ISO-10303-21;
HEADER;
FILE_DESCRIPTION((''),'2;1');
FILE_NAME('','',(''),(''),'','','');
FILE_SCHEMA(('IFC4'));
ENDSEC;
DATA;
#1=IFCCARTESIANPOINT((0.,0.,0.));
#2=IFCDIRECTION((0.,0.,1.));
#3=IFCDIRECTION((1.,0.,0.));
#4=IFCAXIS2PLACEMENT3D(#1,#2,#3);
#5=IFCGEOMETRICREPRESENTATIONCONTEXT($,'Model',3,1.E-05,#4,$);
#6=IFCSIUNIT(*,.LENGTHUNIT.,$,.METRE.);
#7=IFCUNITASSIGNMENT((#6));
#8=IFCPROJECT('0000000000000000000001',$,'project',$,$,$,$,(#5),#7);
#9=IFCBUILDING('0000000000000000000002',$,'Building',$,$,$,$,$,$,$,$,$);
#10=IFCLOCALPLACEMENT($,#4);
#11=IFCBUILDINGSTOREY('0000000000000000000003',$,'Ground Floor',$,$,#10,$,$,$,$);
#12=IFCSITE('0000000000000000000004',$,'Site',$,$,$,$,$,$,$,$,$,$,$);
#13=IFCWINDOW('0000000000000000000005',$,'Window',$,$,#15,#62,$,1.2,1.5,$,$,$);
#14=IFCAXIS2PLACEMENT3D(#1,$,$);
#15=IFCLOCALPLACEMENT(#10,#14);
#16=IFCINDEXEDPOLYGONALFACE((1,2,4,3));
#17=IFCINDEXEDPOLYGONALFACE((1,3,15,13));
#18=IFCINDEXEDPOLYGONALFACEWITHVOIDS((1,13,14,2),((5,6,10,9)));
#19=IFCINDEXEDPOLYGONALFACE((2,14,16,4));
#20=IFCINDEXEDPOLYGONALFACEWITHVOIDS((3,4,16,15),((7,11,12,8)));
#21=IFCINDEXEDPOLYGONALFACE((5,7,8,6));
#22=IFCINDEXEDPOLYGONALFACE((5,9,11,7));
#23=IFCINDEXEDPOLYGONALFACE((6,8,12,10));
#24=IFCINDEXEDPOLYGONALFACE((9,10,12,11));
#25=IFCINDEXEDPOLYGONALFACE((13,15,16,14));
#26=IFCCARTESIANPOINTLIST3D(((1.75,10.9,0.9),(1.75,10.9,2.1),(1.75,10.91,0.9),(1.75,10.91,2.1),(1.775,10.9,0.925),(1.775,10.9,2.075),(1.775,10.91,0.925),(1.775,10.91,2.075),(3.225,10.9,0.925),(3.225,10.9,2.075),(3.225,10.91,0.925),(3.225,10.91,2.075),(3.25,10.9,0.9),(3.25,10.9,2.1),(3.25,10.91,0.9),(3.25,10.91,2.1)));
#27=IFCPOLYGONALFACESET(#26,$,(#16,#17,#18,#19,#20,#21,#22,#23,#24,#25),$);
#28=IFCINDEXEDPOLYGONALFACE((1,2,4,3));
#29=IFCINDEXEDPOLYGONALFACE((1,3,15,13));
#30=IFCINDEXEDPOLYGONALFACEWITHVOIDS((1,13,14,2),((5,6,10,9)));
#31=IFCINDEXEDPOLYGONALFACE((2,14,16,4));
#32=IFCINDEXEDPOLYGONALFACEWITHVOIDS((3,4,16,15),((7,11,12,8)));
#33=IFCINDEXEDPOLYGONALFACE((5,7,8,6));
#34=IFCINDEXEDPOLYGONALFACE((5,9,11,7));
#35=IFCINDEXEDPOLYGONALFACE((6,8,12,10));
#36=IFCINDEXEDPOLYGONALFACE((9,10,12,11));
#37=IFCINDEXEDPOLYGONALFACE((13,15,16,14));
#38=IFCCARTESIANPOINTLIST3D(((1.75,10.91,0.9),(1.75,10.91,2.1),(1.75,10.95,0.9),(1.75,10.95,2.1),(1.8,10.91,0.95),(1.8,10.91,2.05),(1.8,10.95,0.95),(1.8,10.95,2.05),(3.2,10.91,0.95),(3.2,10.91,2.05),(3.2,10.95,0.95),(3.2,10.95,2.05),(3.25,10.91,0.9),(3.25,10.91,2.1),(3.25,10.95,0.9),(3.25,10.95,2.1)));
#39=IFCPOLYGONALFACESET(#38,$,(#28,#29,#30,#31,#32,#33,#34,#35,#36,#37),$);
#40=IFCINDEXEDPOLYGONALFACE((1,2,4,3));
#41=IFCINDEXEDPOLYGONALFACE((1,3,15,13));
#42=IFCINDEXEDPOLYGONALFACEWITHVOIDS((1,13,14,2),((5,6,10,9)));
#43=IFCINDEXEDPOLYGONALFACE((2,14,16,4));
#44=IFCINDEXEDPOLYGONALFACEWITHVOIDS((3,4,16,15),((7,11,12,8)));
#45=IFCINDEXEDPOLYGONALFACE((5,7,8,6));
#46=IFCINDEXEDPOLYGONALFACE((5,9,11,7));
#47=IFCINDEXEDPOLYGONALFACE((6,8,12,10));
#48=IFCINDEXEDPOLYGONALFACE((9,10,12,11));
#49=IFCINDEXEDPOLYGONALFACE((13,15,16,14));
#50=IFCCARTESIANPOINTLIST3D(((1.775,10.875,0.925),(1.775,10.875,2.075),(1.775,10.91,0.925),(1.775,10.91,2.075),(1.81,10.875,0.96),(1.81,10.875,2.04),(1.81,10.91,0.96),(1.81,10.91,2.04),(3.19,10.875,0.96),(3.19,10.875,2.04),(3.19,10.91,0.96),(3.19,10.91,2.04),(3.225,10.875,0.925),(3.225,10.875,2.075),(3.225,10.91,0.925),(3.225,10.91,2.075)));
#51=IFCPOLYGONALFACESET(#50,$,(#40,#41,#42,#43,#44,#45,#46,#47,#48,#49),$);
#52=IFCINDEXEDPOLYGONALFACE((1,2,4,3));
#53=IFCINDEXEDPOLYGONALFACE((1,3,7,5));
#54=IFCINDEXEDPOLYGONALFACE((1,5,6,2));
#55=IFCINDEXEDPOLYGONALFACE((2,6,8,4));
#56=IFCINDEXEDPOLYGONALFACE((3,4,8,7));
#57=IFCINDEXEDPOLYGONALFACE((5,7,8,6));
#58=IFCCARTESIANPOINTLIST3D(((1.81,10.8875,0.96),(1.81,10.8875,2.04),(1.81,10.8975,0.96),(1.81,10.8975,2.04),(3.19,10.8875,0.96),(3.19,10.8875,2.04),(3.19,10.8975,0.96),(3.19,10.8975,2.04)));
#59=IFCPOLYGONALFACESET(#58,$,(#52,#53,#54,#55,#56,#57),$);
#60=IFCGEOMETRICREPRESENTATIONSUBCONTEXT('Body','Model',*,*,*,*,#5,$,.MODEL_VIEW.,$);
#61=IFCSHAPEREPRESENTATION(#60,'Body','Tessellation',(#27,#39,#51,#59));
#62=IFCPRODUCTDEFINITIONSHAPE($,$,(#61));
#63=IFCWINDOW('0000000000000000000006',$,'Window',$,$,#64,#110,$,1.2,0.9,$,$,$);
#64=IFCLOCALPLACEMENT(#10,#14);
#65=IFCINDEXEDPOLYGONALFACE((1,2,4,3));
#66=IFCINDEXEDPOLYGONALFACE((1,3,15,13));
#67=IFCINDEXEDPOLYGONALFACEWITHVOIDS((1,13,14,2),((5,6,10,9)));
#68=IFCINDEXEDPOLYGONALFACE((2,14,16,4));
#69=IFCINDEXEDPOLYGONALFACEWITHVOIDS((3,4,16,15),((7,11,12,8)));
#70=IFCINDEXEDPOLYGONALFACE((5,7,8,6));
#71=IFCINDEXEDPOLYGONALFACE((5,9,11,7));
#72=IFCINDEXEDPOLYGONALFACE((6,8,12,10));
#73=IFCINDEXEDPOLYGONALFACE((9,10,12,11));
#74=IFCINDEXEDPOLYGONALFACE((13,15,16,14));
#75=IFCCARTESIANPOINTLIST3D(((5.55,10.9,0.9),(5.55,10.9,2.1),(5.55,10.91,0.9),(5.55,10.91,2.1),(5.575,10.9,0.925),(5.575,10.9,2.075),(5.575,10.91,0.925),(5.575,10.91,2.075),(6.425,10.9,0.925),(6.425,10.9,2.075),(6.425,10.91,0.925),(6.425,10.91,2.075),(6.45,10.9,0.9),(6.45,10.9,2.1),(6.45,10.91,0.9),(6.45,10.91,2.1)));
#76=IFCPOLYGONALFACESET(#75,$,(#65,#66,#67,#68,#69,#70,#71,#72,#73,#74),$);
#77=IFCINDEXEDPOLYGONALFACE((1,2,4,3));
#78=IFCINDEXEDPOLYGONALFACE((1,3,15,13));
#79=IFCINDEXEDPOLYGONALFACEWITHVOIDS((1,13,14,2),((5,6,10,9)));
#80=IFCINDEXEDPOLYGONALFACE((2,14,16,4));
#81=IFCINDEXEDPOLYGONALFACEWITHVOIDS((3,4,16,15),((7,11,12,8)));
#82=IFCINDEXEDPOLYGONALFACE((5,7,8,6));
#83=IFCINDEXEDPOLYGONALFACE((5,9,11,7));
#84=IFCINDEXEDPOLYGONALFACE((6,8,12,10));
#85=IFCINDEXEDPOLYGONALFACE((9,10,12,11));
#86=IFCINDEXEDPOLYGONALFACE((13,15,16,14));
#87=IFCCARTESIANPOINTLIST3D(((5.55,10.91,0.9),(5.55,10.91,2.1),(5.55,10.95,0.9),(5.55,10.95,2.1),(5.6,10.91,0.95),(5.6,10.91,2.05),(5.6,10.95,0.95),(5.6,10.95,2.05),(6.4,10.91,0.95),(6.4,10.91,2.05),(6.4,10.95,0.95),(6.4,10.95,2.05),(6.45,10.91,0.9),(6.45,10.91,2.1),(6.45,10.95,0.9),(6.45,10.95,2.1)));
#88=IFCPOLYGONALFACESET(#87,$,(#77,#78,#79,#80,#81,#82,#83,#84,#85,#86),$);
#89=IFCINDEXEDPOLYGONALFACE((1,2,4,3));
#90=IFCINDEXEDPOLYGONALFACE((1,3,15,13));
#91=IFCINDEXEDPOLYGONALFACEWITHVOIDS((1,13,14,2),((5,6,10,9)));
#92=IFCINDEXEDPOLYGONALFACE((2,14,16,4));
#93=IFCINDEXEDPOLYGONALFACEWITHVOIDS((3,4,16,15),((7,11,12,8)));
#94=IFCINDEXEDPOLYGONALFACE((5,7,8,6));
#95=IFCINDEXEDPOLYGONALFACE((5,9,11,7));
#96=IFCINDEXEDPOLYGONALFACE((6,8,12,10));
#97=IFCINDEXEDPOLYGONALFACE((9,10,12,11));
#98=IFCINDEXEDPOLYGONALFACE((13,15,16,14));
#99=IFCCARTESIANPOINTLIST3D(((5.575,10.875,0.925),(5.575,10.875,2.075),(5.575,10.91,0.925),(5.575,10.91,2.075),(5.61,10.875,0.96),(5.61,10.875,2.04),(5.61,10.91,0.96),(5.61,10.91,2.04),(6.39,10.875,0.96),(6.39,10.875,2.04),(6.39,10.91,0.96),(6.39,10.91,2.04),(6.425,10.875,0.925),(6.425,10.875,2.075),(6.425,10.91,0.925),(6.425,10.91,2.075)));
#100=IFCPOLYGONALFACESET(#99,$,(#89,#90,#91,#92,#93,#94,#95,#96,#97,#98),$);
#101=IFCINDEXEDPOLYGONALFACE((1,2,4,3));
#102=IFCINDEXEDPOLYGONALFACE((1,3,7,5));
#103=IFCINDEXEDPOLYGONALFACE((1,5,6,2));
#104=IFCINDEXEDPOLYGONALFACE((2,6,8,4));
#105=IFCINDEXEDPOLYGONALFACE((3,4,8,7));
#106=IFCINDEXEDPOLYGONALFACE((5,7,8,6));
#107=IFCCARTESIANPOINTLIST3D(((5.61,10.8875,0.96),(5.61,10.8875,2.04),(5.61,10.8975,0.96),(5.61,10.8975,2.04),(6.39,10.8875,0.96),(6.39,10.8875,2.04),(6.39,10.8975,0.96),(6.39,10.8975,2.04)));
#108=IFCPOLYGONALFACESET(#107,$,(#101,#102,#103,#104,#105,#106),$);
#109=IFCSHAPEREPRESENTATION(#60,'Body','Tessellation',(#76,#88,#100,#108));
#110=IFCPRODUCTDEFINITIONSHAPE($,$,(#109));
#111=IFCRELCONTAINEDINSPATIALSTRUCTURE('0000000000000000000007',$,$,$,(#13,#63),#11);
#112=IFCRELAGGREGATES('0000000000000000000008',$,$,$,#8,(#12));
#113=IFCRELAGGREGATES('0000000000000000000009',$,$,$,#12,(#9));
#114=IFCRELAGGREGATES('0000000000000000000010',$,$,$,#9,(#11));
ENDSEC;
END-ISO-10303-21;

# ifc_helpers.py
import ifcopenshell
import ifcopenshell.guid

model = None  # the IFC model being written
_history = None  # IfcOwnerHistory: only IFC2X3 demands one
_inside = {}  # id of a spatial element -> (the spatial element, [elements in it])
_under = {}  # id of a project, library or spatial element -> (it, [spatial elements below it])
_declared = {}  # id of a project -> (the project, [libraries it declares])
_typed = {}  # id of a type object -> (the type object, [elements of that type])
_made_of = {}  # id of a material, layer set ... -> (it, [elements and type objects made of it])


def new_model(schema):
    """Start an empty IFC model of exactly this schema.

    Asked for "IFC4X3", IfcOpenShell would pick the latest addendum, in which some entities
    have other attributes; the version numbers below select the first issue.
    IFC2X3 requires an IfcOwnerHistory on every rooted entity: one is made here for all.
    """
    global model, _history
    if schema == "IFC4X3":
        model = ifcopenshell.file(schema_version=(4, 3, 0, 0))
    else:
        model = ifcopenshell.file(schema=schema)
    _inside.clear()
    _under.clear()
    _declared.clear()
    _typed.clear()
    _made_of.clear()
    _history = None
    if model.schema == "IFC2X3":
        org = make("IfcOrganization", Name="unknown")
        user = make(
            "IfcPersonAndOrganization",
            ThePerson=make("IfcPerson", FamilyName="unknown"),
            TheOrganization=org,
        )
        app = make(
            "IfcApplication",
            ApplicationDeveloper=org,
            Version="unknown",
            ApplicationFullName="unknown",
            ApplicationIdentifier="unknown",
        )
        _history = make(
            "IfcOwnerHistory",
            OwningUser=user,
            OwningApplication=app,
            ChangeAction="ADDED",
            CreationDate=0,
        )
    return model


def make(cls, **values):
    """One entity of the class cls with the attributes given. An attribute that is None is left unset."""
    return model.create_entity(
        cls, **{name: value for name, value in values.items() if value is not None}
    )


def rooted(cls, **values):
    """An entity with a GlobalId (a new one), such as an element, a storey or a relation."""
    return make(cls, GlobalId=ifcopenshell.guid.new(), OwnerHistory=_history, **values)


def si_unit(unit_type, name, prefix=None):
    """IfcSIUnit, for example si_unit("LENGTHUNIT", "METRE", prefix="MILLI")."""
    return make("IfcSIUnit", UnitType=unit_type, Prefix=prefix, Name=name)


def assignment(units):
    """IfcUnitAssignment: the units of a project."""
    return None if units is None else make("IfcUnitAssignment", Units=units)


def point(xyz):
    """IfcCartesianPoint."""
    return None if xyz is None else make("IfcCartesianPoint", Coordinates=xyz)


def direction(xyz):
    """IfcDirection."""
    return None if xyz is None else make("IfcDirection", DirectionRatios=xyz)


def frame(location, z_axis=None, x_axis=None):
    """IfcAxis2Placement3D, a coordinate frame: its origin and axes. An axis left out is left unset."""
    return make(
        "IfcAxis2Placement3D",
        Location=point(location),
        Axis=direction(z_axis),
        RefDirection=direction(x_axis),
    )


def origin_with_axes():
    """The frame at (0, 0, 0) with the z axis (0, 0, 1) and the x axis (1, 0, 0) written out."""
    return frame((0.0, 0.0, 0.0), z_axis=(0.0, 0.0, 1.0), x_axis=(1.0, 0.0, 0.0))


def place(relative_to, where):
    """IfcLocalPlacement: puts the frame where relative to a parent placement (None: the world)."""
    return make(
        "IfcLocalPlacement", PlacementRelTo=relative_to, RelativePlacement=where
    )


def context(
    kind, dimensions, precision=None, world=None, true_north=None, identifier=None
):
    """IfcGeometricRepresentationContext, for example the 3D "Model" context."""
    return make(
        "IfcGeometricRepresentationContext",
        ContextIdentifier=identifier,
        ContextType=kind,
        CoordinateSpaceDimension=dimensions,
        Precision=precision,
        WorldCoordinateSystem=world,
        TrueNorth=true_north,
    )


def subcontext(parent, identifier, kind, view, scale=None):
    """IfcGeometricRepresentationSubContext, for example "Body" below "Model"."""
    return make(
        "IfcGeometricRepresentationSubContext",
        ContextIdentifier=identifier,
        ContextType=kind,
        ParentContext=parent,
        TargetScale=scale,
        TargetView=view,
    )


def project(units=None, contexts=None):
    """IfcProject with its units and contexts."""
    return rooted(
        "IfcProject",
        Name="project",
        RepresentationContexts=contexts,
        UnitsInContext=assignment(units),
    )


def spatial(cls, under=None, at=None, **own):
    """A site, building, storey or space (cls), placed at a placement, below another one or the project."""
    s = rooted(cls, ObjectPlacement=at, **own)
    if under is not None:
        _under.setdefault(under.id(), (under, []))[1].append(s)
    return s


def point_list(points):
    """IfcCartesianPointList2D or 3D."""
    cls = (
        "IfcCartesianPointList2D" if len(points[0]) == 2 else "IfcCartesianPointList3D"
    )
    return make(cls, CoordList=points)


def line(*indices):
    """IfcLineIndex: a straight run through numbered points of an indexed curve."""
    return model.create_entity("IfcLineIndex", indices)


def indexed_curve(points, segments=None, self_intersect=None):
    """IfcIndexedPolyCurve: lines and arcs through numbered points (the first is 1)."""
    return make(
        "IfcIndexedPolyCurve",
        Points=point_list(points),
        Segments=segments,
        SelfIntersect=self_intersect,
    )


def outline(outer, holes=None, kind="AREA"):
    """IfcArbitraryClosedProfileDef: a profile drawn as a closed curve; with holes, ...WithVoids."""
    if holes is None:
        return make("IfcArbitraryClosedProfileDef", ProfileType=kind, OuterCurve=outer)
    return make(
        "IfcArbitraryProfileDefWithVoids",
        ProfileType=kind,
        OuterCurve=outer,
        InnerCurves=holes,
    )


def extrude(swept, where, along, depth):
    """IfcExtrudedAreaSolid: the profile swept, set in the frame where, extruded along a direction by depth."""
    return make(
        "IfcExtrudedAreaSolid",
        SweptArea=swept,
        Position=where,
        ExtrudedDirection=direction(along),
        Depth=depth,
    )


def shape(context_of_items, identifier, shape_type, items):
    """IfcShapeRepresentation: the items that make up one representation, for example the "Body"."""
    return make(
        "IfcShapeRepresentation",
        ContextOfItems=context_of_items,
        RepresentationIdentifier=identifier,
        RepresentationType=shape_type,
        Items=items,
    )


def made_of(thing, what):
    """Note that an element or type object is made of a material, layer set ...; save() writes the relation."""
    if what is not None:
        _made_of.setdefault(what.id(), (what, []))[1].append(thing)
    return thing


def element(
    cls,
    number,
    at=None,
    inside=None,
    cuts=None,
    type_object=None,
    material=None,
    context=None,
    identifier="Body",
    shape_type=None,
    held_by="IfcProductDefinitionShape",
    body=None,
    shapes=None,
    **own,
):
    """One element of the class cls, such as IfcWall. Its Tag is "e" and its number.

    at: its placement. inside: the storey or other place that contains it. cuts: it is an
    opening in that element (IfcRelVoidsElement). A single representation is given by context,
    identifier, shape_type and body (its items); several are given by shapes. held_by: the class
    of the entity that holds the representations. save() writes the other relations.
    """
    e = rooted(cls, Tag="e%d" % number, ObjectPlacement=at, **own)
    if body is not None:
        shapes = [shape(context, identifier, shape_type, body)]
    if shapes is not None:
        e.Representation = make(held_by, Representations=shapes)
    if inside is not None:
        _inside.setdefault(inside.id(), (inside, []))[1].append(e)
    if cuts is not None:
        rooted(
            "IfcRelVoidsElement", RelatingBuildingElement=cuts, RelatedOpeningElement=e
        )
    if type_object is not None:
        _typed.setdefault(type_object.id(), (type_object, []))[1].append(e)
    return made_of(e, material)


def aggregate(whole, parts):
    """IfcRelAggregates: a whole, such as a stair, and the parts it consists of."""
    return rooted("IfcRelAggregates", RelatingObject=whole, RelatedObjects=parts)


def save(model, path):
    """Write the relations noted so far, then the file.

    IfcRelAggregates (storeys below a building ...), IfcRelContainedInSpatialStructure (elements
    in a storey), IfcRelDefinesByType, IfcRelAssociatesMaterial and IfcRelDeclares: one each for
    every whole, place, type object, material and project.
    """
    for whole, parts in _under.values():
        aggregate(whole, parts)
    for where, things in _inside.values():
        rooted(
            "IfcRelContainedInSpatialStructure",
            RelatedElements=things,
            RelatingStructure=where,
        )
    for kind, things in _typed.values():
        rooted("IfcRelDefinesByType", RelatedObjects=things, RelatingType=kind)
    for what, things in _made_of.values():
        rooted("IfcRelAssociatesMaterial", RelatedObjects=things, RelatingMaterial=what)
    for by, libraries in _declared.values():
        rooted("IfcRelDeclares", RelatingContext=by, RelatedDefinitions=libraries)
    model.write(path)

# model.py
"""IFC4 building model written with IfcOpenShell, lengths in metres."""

from ifc_helpers import new_model, si_unit, frame, origin_with_axes, place, context, subcontext, project, spatial, line, indexed_curve, outline, extrude, element, save


model = new_model("IFC4")

# Units and contexts
model_context = context("Model", 3, precision=1e-05, world=origin_with_axes())
body_context = subcontext(model_context, "Body", "Model", "MODEL_VIEW")
ifc_project = project(units=[si_unit("LENGTHUNIT", "METRE")], contexts=[model_context])

# Site, building, storey
site = spatial("IfcSite", under=ifc_project, Name="Site")
building = spatial("IfcBuilding", under=site, Name="Building")
storey_placement = place(None, origin_with_axes())
storey = spatial("IfcBuildingStorey", under=building, at=storey_placement, Name="Ground Floor")

# Windows
window_1_placement = place(storey_placement, frame((3.25, 11.0, 0.9), z_axis=(0.0, 0.0, 1.0), x_axis=(-1.0, 0.0, 0.0)))
element("IfcWindow", 1, at=window_1_placement, inside=storey, Name="Window", OverallHeight=1.2, OverallWidth=1.5, context=body_context, shape_type="SweptSolid", body=[
    extrude(outline(indexed_curve([(0.0, 0.0), (1.5, 0.0), (1.5, 1.2), (0.0, 1.2)], segments=[line(1, 2, 3, 4, 1)]), holes=[indexed_curve([(0.025, 0.025), (1.475, 0.025), (1.475, 1.175), (0.025, 1.175)], segments=[line(1, 2, 3, 4, 1)])]), frame((0.0, 0.09, 0.0), z_axis=(0.0, -1.0, 0.0), x_axis=(1.0, 0.0, 0.0)), (0.0, 0.0, -1.0), 0.01),
    extrude(outline(indexed_curve([(0.0, 0.0), (1.5, 0.0), (1.5, 1.2), (0.0, 1.2)], segments=[line(1, 2, 3, 4, 1)]), holes=[indexed_curve([(0.05, 0.05), (1.45, 0.05), (1.45, 1.15), (0.05, 1.15)], segments=[line(1, 2, 3, 4, 1)])]), frame((0.0, 0.05, 0.0), z_axis=(0.0, -1.0, 0.0), x_axis=(1.0, 0.0, 0.0)), (0.0, 0.0, -1.0), 0.04),
    extrude(outline(indexed_curve([(0.0, 0.0), (1.45, 0.0), (1.45, 1.15), (0.0, 1.15)], segments=[line(1, 2, 3, 4, 1)]), holes=[indexed_curve([(0.035, 0.035), (1.415, 0.035), (1.415, 1.115), (0.035, 1.115)], segments=[line(1, 2, 3, 4, 1)])]), frame((0.025, 0.09, 0.025), z_axis=(0.0, -1.0, 0.0), x_axis=(1.0, 0.0, 0.0)), (0.0, 0.0, -1.0), 0.035),
    extrude(outline(indexed_curve([(0.035, 0.035), (1.415, 0.035), (1.415, 1.115), (0.035, 1.115)], segments=[line(1, 2, 3, 4, 1)])), frame((0.025, 0.1025, 0.025), z_axis=(0.0, -1.0, 0.0), x_axis=(1.0, 0.0, 0.0)), (0.0, 0.0, -1.0), 0.01),
])
window_2_placement = place(storey_placement, frame((6.45, 11.0, 0.9), z_axis=(0.0, 0.0, 1.0), x_axis=(-1.0, 0.0, 0.0)))
element("IfcWindow", 2, at=window_2_placement, inside=storey, Name="Window", OverallHeight=1.2, OverallWidth=0.9, context=body_context, shape_type="SweptSolid", body=[
    extrude(outline(indexed_curve([(0.0, 0.0), (0.9, 0.0), (0.9, 1.2), (0.0, 1.2)], segments=[line(1, 2, 3, 4, 1)]), holes=[indexed_curve([(0.025, 0.025), (0.875, 0.025), (0.875, 1.175), (0.025, 1.175)], segments=[line(1, 2, 3, 4, 1)])]), frame((0.0, 0.09, 0.0), z_axis=(0.0, -1.0, 0.0), x_axis=(1.0, 0.0, 0.0)), (0.0, 0.0, -1.0), 0.01),
    extrude(outline(indexed_curve([(0.0, 0.0), (0.9, 0.0), (0.9, 1.2), (0.0, 1.2)], segments=[line(1, 2, 3, 4, 1)]), holes=[indexed_curve([(0.05, 0.05), (0.85, 0.05), (0.85, 1.15), (0.05, 1.15)], segments=[line(1, 2, 3, 4, 1)])]), frame((0.0, 0.05, 0.0), z_axis=(0.0, -1.0, 0.0), x_axis=(1.0, 0.0, 0.0)), (0.0, 0.0, -1.0), 0.04),
    extrude(outline(indexed_curve([(0.0, 0.0), (0.85, 0.0), (0.85, 1.15), (0.0, 1.15)], segments=[line(1, 2, 3, 4, 1)]), holes=[indexed_curve([(0.035, 0.035), (0.815, 0.035), (0.815, 1.115), (0.035, 1.115)], segments=[line(1, 2, 3, 4, 1)])]), frame((0.025, 0.09, 0.025), z_axis=(0.0, -1.0, 0.0), x_axis=(1.0, 0.0, 0.0)), (0.0, 0.0, -1.0), 0.035),
    extrude(outline(indexed_curve([(0.035, 0.035), (0.815, 0.035), (0.815, 1.115), (0.035, 1.115)], segments=[line(1, 2, 3, 4, 1)])), frame((0.025, 0.1025, 0.025), z_axis=(0.0, -1.0, 0.0), x_axis=(1.0, 0.0, 0.0)), (0.0, 0.0, -1.0), 0.01),
])

save(model, "model.ifc")
